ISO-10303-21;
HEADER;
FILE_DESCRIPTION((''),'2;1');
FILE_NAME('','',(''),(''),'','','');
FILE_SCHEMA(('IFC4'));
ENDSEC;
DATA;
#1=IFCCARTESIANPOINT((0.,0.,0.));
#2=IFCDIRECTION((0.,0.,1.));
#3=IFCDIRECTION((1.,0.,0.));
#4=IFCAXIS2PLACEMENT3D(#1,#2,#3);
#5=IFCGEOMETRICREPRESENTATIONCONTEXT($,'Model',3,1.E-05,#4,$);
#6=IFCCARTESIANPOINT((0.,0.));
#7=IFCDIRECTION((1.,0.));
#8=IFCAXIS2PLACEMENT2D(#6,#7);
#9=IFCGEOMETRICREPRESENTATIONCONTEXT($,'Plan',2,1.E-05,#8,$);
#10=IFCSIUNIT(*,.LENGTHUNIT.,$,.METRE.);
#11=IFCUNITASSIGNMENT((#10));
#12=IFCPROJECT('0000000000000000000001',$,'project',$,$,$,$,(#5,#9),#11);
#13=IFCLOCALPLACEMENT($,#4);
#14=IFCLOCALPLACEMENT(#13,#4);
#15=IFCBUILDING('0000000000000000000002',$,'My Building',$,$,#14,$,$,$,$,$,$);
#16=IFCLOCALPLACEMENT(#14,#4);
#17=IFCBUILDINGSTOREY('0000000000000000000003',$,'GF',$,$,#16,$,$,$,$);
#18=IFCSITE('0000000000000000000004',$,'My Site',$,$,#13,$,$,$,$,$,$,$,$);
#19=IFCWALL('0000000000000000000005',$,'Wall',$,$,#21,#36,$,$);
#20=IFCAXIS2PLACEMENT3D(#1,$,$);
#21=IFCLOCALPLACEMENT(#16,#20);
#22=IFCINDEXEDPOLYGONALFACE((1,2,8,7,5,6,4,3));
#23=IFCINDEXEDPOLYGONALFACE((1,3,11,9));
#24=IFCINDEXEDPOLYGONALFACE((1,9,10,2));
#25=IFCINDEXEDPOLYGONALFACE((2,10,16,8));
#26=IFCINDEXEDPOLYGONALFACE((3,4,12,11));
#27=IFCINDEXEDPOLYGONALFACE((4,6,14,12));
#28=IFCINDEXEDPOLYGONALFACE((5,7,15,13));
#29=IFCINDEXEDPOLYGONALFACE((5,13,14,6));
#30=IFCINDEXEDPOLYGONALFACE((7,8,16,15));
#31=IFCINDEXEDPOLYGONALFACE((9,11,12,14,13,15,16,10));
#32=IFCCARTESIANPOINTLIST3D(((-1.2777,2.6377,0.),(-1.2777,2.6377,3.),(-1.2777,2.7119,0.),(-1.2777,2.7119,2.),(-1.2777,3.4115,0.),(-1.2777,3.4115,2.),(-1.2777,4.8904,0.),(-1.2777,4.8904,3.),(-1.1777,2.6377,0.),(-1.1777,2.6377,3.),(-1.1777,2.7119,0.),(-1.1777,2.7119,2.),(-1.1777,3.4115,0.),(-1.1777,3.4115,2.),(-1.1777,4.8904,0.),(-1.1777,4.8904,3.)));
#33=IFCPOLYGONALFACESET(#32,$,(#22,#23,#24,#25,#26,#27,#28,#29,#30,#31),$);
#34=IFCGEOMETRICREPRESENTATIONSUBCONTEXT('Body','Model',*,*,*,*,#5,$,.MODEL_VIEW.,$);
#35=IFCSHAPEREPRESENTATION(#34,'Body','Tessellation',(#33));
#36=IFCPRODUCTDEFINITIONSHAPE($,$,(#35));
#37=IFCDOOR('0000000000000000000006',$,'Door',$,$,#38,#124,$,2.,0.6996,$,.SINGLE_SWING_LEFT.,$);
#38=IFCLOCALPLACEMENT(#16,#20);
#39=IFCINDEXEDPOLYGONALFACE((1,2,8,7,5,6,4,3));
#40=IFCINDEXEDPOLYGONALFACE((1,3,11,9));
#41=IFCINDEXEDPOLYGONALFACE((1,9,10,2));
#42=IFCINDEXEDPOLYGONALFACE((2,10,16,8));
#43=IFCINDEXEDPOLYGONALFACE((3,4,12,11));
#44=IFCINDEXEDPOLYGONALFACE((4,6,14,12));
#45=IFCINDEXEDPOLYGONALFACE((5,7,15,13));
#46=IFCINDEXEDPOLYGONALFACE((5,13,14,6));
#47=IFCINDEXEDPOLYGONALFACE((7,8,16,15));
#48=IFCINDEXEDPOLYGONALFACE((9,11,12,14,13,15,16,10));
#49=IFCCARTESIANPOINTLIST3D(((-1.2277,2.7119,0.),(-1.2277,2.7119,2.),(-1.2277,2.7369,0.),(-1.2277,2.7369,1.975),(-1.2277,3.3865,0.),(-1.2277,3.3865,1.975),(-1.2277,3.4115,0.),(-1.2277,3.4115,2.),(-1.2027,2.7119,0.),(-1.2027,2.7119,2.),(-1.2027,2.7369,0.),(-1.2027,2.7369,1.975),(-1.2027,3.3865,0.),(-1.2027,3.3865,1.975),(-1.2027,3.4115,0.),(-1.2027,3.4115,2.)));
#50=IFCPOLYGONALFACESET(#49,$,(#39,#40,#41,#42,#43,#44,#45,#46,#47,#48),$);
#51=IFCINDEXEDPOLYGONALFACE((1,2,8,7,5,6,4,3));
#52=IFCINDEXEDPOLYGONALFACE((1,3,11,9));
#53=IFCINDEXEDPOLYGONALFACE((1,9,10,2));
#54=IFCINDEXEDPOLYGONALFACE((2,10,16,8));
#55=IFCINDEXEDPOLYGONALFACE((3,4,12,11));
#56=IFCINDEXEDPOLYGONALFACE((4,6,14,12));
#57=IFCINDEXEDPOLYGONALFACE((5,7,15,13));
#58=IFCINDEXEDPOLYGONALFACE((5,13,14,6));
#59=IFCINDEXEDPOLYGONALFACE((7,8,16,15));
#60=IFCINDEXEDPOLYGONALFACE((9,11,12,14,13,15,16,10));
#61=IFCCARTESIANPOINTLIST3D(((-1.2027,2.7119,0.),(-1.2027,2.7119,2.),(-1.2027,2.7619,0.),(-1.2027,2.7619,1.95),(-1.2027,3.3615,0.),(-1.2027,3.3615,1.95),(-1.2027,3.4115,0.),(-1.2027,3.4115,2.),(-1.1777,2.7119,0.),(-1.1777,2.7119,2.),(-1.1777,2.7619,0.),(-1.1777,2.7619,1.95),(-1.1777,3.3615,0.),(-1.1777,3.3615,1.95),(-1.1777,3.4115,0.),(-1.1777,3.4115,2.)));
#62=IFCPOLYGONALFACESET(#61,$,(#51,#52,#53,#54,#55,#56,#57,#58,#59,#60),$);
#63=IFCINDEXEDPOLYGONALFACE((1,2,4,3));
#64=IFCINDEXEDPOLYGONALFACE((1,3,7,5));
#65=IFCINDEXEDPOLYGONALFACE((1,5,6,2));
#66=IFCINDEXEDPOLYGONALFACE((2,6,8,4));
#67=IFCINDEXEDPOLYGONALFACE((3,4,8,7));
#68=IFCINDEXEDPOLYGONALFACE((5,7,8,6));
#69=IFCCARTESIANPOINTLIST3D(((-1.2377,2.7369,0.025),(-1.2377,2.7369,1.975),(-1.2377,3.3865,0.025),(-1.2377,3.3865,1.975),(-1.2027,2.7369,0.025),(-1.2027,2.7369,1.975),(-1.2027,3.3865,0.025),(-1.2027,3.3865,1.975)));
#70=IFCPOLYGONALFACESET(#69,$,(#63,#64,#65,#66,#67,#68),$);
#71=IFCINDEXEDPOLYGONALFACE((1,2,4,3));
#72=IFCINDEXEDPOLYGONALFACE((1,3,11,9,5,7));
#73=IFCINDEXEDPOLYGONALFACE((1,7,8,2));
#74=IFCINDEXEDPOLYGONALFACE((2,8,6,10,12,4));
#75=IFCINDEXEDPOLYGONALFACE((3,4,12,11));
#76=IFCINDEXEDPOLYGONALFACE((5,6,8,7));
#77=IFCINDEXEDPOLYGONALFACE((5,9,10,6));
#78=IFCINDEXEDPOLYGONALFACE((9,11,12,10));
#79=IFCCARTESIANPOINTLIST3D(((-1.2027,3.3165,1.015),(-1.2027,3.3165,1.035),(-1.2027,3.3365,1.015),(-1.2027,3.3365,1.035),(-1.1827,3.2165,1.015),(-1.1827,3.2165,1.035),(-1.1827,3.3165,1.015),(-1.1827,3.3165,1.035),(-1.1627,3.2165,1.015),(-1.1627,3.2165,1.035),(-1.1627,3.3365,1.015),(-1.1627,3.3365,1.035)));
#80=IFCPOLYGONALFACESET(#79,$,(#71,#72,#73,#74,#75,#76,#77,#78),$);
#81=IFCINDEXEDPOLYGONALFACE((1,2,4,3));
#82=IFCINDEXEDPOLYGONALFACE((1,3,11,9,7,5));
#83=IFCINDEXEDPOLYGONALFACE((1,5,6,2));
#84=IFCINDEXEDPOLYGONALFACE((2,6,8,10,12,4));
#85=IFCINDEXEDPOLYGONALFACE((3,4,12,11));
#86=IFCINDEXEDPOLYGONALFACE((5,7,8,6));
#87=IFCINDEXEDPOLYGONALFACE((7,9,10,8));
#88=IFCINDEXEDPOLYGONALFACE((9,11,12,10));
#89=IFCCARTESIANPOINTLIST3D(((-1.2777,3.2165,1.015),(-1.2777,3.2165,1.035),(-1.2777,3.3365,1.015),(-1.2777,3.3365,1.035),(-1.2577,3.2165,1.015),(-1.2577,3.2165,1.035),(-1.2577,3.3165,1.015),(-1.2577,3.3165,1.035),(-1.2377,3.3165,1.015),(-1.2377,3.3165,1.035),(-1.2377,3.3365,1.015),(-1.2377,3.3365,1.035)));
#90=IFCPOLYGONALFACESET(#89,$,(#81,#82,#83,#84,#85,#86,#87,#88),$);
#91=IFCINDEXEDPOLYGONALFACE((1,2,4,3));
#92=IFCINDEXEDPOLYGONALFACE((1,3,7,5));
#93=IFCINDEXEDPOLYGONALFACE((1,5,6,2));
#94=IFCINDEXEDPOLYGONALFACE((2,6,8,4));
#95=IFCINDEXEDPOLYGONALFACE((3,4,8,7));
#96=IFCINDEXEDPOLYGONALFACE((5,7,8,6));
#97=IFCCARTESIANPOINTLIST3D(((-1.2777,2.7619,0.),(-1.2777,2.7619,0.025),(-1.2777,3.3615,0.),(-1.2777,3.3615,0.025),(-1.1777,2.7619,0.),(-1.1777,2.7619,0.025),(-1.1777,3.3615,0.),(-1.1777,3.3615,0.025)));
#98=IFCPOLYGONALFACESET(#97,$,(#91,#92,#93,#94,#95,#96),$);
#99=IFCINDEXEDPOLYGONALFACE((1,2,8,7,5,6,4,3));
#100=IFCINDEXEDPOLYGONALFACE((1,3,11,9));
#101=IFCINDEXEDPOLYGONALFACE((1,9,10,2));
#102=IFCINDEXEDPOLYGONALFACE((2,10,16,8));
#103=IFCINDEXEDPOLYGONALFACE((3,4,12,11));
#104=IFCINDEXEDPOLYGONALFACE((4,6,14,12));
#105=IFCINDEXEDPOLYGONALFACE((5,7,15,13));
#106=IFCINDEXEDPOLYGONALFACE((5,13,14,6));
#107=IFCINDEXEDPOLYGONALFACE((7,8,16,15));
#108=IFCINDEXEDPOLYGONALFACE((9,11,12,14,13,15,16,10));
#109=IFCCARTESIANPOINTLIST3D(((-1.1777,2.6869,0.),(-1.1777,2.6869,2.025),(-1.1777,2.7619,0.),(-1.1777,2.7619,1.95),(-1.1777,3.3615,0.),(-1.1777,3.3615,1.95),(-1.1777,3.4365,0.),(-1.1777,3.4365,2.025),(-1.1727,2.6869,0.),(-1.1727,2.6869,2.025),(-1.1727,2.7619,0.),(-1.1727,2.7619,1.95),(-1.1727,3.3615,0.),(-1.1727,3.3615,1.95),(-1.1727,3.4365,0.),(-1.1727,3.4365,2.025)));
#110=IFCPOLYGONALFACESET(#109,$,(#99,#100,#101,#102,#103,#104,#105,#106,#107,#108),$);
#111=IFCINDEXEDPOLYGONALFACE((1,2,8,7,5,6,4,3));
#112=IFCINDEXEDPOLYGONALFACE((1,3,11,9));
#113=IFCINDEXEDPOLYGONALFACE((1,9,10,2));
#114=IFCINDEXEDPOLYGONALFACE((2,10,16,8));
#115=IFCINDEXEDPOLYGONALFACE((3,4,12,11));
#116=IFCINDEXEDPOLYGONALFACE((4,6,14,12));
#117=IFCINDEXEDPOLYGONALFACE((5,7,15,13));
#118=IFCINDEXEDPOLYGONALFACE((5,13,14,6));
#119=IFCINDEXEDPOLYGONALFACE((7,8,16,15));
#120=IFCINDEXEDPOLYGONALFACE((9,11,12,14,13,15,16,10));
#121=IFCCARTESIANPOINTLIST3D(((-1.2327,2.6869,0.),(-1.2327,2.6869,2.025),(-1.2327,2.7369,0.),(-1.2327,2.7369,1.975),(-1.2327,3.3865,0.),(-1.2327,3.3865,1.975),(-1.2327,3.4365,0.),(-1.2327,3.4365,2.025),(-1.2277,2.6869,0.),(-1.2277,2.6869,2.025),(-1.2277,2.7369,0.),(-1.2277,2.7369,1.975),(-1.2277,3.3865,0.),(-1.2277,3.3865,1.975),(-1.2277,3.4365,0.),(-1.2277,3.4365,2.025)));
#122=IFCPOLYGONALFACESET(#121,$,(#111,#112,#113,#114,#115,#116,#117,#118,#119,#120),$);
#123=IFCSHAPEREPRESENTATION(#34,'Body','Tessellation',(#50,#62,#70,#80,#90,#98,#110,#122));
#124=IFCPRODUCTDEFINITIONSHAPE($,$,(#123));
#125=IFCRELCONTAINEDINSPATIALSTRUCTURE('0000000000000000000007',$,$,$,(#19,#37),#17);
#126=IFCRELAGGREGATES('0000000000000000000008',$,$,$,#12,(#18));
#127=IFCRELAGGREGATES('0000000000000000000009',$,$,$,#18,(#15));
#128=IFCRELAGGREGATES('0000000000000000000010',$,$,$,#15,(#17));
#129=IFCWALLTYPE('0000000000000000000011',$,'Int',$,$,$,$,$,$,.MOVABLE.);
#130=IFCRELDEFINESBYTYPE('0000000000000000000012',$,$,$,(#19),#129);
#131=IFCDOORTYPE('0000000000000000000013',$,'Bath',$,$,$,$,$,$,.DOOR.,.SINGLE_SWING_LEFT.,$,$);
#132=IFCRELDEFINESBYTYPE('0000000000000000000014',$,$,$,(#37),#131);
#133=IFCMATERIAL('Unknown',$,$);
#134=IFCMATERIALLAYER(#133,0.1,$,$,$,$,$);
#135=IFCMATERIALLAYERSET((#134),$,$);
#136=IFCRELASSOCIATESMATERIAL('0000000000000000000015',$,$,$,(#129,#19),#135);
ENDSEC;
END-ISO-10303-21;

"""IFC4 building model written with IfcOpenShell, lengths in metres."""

from ifc_helpers import new_model, entity, si_unit, frame, origin_with_axes, origin_2d_with_axis, place, context, subcontext, project, spatial, line, indexed_curve, outline, extrude, shape, source, transform, mapped, material, layer, layer_set, layer_usage, type_object, type_shapes, element, fill, save


model = new_model("IFC4")

# Units and contexts
model_context = context("Model", 3, precision=1e-05, world=origin_with_axes())
plan_context = context("Plan", 2, precision=1e-05, world=origin_2d_with_axis())
body_context_1 = subcontext(model_context, "Body", "Model", "MODEL_VIEW")
body_context_2 = subcontext(plan_context, "Body", "Plan", "PLAN_VIEW")
ifc_project = project(units=[si_unit("LENGTHUNIT", "METRE")], contexts=[model_context, plan_context])

# Site, building, storey
site_placement = place(None, origin_with_axes())
site = spatial("IfcSite", under=ifc_project, at=site_placement, Name="My Site")
building_placement = place(site_placement, origin_with_axes())
building = spatial("IfcBuilding", under=site, at=building_placement, Name="My Building")
storey_placement = place(building_placement, origin_with_axes())
storey = spatial("IfcBuildingStorey", under=building, at=storey_placement, Name="GF")

# Shared definitions
ifc_material = material(Name="Unknown")

# Wall, opening, door
ifc_layer_1 = layer(ifc_material, 0.1)
ifc_layer_set_1 = layer_set([ifc_layer_1])
wall_type_1 = type_object("IfcWallType", Name="Int", PredefinedType="MOVABLE", material=ifc_layer_set_1)
ifc_layer_usage_1 = layer_usage(ifc_layer_set_1, "AXIS2", "POSITIVE", 0.0)
wall_1_placement = place(storey_placement, frame((-1.2777, 4.8904, 0.0), z_axis=(0.0, 0.0, 1.0), x_axis=(0.0, -1.0, 0.0)))
wall_1 = element("IfcWall", 1, at=wall_1_placement, inside=storey, type_object=wall_type_1, material=ifc_layer_usage_1, Name="Wall", context=body_context_1, shape_type="SweptSolid", body=[
    extrude(outline(indexed_curve([(0.0, 0.0), (0.0, 0.1), (2.2527, 0.1), (2.2527, 0.0)], segments=[line(1, 2, 3, 4, 1)])), origin_with_axes(), (0.0, 0.0, 1.0), 3.0),
])
shared_shape_1 = source(origin_with_axes(), body_context_1, "Body", "SweptSolid", [
    extrude(outline(indexed_curve([(0.0, 0.0), (0.6996, 0.0), (0.6996, 2.0), (0.0, 2.0)], segments=[line(1, 2, 3, 4, 1)])), frame((0.0, -0.6, 0.0), z_axis=(0.0, -1.0, 0.0), x_axis=(1.0, 0.0, 0.0)), (0.0, 0.0, -1.0), 1.2),
])
opening_1_placement = place(wall_1_placement, frame((2.1785, 0.1, 0.0), z_axis=(0.0, 0.0, 1.0), x_axis=(-1.0, 0.0, 0.0)))
opening_1 = element("IfcOpeningElement", 2, at=opening_1_placement, cuts=wall_1, PredefinedType="OPENING", context=body_context_1, shape_type="MappedRepresentation", body=[
    mapped(shared_shape_1, transform((0.0, 0.0, 0.0), x_axis=(1.0, 0.0, 0.0), y_axis=(0.0, 1.0, 0.0), z_axis=(0.0, 0.0, 1.0), scale=1.0)),
])
door_type_1 = type_object("IfcDoorType", Name="Bath", OperationType="SINGLE_SWING_LEFT", PredefinedType="DOOR")
shared_shape_2 = source(origin_with_axes(), body_context_1, "Body", "SweptSolid", [
    extrude(outline(indexed_curve([(0.0, 0.0), (0.0, 2.0), (0.6996, 2.0), (0.6996, 0.0), (0.6746, 0.0), (0.6746, 1.975), (0.025, 1.975), (0.025, 0.0)], segments=[line(1, 2, 3, 4, 5, 6, 7, 8, 1)])), frame((0.0, 0.025, 0.0), z_axis=(0.0, -1.0, 0.0), x_axis=(1.0, 0.0, 0.0)), (0.0, 0.0, -1.0), 0.025),
    extrude(outline(indexed_curve([(0.0, 0.0), (0.0, 2.0), (0.6996, 2.0), (0.6996, 0.0), (0.6496, 0.0), (0.6496, 1.95), (0.05, 1.95), (0.05, 0.0)], segments=[line(1, 2, 3, 4, 5, 6, 7, 8, 1)])), frame((0.0, 0.0, 0.0), z_axis=(0.0, -1.0, 0.0), x_axis=(1.0, 0.0, 0.0)), (0.0, 0.0, -1.0), 0.025),
    extrude(outline(indexed_curve([(0.0, 0.0), (0.6496, 0.0), (0.6496, 0.035), (0.0, 0.035)], segments=[line(1, 2, 3, 4, 1)])), frame((0.025, 0.025, 0.025), z_axis=(0.0, 0.0, 1.0), x_axis=(1.0, 0.0, 0.0)), (0.0, 0.0, 1.0), 1.95),
    extrude(outline(indexed_curve([(0.0, 0.0), (0.0, -0.04), (-0.12, -0.04), (-0.12, -0.02), (-0.02, -0.02), (-0.02, 0.0)], segments=[line(1, 2, 3, 4, 5, 6, 1)])), frame((0.6246, 0.025, 1.015), z_axis=(0.0, 0.0, 1.0), x_axis=(1.0, 0.0, 0.0)), (0.0, 0.0, 1.0), 0.02),
    extrude(outline(indexed_curve([(0.0, 0.0), (0.0, 0.04), (-0.12, 0.04), (-0.12, 0.02), (-0.02, 0.02), (-0.02, 0.0)], segments=[line(1, 2, 3, 4, 5, 6, 1)])), frame((0.6246, 0.06, 1.015), z_axis=(0.0, 0.0, 1.0), x_axis=(1.0, 0.0, 0.0)), (0.0, 0.0, 1.0), 0.02),
    extrude(outline(indexed_curve([(0.0, 0.0), (0.5996, 0.0), (0.5996, 0.1), (0.0, 0.1)], segments=[line(1, 2, 3, 4, 1)])), frame((0.05, 0.0, 0.0), z_axis=(0.0, 0.0, 1.0), x_axis=(1.0, 0.0, 0.0)), (0.0, 0.0, 1.0), 0.025),
    extrude(outline(indexed_curve([(0.0, 0.0), (0.0, 2.025), (0.7496, 2.025), (0.7496, 0.0), (0.6746, 0.0), (0.6746, 1.95), (0.075, 1.95), (0.075, 0.0)], segments=[line(1, 2, 3, 4, 5, 6, 7, 8, 1)])), frame((-0.025, -0.005, 0.0), z_axis=(0.0, -1.0, 0.0), x_axis=(1.0, 0.0, 0.0)), (0.0, 0.0, -1.0), 0.005),
    extrude(outline(indexed_curve([(0.0, 0.0), (0.0, 2.025), (0.7496, 2.025), (0.7496, 0.0), (0.6996, 0.0), (0.6996, 1.975), (0.05, 1.975), (0.05, 0.0)], segments=[line(1, 2, 3, 4, 5, 6, 7, 8, 1)])), frame((-0.025, 0.05, 0.0), z_axis=(0.0, -1.0, 0.0), x_axis=(1.0, 0.0, 0.0)), (0.0, 0.0, -1.0), 0.005),
])
shared_shape_3 = source(origin_with_axes(), body_context_2, "Body", "Curve2D", [
    entity("IfcIndexedPolyCurve", entity("IfcCartesianPointList2D", [[0.0, 0.0], [0.0, 0.05], [0.025, 0.05], [0.025, 0.025], [0.05, 0.025], [0.05, 0.0]]), [entity("IfcLineIndex", [1, 2, 3, 4, 5, 6, 1])]),
    entity("IfcIndexedPolyCurve", entity("IfcCartesianPointList2D", [[0.6996, 0.0], [0.6996, 0.05], [0.6746, 0.05], [0.6746, 0.025], [0.6496, 0.025], [0.6496, 0.0]]), [entity("IfcLineIndex", [1, 2, 3, 4, 5, 6, 1])]),
    entity("IfcTrimmedCurve", entity("IfcEllipse", entity("IfcAxis2Placement2D", entity("IfcCartesianPoint", [0.06, 0.05]), entity("IfcDirection", [1.0, 0.0])), 0.6146, 0.6496), [entity("IfcCartesianPoint", [0.6746, 0.05])], [entity("IfcCartesianPoint", [0.06, 0.6996])], True, "CARTESIAN"),
    entity("IfcIndexedPolyCurve", entity("IfcCartesianPointList2D", [[0.025, 0.05], [0.06, 0.05], [0.06, 0.6996], [0.025, 0.6996]]), [entity("IfcLineIndex", [1, 2, 3, 4, 1])]),
])
type_shapes(door_type_1, [shared_shape_2, shared_shape_3])
door_1_placement = place(opening_1_placement, frame((0.0, 0.0, 0.0), z_axis=(0.0, 0.0, 1.0), x_axis=(1.0, 0.0, 0.0)))
door_1 = element("IfcDoor", 3, at=door_1_placement, inside=storey, type_object=door_type_1, Name="Door", OperationType="SINGLE_SWING_LEFT", OverallHeight=2.0, OverallWidth=0.6996, shapes=[
    shape(body_context_1, "Body", "MappedRepresentation", [mapped(shared_shape_2, transform((0.0, 0.0, 0.0), x_axis=(1.0, 0.0, 0.0), y_axis=(0.0, 1.0, 0.0), z_axis=(0.0, 0.0, 1.0), scale=1.0))]),
    shape(body_context_2, "Body", "MappedRepresentation", [mapped(shared_shape_3, transform((0.0, 0.0, 0.0), x_axis=(1.0, 0.0, 0.0), y_axis=(0.0, 1.0, 0.0), z_axis=(0.0, 0.0, 1.0), scale=1.0))]),
])
fill(opening_1, door_1)

save(model, "model.ifc")
